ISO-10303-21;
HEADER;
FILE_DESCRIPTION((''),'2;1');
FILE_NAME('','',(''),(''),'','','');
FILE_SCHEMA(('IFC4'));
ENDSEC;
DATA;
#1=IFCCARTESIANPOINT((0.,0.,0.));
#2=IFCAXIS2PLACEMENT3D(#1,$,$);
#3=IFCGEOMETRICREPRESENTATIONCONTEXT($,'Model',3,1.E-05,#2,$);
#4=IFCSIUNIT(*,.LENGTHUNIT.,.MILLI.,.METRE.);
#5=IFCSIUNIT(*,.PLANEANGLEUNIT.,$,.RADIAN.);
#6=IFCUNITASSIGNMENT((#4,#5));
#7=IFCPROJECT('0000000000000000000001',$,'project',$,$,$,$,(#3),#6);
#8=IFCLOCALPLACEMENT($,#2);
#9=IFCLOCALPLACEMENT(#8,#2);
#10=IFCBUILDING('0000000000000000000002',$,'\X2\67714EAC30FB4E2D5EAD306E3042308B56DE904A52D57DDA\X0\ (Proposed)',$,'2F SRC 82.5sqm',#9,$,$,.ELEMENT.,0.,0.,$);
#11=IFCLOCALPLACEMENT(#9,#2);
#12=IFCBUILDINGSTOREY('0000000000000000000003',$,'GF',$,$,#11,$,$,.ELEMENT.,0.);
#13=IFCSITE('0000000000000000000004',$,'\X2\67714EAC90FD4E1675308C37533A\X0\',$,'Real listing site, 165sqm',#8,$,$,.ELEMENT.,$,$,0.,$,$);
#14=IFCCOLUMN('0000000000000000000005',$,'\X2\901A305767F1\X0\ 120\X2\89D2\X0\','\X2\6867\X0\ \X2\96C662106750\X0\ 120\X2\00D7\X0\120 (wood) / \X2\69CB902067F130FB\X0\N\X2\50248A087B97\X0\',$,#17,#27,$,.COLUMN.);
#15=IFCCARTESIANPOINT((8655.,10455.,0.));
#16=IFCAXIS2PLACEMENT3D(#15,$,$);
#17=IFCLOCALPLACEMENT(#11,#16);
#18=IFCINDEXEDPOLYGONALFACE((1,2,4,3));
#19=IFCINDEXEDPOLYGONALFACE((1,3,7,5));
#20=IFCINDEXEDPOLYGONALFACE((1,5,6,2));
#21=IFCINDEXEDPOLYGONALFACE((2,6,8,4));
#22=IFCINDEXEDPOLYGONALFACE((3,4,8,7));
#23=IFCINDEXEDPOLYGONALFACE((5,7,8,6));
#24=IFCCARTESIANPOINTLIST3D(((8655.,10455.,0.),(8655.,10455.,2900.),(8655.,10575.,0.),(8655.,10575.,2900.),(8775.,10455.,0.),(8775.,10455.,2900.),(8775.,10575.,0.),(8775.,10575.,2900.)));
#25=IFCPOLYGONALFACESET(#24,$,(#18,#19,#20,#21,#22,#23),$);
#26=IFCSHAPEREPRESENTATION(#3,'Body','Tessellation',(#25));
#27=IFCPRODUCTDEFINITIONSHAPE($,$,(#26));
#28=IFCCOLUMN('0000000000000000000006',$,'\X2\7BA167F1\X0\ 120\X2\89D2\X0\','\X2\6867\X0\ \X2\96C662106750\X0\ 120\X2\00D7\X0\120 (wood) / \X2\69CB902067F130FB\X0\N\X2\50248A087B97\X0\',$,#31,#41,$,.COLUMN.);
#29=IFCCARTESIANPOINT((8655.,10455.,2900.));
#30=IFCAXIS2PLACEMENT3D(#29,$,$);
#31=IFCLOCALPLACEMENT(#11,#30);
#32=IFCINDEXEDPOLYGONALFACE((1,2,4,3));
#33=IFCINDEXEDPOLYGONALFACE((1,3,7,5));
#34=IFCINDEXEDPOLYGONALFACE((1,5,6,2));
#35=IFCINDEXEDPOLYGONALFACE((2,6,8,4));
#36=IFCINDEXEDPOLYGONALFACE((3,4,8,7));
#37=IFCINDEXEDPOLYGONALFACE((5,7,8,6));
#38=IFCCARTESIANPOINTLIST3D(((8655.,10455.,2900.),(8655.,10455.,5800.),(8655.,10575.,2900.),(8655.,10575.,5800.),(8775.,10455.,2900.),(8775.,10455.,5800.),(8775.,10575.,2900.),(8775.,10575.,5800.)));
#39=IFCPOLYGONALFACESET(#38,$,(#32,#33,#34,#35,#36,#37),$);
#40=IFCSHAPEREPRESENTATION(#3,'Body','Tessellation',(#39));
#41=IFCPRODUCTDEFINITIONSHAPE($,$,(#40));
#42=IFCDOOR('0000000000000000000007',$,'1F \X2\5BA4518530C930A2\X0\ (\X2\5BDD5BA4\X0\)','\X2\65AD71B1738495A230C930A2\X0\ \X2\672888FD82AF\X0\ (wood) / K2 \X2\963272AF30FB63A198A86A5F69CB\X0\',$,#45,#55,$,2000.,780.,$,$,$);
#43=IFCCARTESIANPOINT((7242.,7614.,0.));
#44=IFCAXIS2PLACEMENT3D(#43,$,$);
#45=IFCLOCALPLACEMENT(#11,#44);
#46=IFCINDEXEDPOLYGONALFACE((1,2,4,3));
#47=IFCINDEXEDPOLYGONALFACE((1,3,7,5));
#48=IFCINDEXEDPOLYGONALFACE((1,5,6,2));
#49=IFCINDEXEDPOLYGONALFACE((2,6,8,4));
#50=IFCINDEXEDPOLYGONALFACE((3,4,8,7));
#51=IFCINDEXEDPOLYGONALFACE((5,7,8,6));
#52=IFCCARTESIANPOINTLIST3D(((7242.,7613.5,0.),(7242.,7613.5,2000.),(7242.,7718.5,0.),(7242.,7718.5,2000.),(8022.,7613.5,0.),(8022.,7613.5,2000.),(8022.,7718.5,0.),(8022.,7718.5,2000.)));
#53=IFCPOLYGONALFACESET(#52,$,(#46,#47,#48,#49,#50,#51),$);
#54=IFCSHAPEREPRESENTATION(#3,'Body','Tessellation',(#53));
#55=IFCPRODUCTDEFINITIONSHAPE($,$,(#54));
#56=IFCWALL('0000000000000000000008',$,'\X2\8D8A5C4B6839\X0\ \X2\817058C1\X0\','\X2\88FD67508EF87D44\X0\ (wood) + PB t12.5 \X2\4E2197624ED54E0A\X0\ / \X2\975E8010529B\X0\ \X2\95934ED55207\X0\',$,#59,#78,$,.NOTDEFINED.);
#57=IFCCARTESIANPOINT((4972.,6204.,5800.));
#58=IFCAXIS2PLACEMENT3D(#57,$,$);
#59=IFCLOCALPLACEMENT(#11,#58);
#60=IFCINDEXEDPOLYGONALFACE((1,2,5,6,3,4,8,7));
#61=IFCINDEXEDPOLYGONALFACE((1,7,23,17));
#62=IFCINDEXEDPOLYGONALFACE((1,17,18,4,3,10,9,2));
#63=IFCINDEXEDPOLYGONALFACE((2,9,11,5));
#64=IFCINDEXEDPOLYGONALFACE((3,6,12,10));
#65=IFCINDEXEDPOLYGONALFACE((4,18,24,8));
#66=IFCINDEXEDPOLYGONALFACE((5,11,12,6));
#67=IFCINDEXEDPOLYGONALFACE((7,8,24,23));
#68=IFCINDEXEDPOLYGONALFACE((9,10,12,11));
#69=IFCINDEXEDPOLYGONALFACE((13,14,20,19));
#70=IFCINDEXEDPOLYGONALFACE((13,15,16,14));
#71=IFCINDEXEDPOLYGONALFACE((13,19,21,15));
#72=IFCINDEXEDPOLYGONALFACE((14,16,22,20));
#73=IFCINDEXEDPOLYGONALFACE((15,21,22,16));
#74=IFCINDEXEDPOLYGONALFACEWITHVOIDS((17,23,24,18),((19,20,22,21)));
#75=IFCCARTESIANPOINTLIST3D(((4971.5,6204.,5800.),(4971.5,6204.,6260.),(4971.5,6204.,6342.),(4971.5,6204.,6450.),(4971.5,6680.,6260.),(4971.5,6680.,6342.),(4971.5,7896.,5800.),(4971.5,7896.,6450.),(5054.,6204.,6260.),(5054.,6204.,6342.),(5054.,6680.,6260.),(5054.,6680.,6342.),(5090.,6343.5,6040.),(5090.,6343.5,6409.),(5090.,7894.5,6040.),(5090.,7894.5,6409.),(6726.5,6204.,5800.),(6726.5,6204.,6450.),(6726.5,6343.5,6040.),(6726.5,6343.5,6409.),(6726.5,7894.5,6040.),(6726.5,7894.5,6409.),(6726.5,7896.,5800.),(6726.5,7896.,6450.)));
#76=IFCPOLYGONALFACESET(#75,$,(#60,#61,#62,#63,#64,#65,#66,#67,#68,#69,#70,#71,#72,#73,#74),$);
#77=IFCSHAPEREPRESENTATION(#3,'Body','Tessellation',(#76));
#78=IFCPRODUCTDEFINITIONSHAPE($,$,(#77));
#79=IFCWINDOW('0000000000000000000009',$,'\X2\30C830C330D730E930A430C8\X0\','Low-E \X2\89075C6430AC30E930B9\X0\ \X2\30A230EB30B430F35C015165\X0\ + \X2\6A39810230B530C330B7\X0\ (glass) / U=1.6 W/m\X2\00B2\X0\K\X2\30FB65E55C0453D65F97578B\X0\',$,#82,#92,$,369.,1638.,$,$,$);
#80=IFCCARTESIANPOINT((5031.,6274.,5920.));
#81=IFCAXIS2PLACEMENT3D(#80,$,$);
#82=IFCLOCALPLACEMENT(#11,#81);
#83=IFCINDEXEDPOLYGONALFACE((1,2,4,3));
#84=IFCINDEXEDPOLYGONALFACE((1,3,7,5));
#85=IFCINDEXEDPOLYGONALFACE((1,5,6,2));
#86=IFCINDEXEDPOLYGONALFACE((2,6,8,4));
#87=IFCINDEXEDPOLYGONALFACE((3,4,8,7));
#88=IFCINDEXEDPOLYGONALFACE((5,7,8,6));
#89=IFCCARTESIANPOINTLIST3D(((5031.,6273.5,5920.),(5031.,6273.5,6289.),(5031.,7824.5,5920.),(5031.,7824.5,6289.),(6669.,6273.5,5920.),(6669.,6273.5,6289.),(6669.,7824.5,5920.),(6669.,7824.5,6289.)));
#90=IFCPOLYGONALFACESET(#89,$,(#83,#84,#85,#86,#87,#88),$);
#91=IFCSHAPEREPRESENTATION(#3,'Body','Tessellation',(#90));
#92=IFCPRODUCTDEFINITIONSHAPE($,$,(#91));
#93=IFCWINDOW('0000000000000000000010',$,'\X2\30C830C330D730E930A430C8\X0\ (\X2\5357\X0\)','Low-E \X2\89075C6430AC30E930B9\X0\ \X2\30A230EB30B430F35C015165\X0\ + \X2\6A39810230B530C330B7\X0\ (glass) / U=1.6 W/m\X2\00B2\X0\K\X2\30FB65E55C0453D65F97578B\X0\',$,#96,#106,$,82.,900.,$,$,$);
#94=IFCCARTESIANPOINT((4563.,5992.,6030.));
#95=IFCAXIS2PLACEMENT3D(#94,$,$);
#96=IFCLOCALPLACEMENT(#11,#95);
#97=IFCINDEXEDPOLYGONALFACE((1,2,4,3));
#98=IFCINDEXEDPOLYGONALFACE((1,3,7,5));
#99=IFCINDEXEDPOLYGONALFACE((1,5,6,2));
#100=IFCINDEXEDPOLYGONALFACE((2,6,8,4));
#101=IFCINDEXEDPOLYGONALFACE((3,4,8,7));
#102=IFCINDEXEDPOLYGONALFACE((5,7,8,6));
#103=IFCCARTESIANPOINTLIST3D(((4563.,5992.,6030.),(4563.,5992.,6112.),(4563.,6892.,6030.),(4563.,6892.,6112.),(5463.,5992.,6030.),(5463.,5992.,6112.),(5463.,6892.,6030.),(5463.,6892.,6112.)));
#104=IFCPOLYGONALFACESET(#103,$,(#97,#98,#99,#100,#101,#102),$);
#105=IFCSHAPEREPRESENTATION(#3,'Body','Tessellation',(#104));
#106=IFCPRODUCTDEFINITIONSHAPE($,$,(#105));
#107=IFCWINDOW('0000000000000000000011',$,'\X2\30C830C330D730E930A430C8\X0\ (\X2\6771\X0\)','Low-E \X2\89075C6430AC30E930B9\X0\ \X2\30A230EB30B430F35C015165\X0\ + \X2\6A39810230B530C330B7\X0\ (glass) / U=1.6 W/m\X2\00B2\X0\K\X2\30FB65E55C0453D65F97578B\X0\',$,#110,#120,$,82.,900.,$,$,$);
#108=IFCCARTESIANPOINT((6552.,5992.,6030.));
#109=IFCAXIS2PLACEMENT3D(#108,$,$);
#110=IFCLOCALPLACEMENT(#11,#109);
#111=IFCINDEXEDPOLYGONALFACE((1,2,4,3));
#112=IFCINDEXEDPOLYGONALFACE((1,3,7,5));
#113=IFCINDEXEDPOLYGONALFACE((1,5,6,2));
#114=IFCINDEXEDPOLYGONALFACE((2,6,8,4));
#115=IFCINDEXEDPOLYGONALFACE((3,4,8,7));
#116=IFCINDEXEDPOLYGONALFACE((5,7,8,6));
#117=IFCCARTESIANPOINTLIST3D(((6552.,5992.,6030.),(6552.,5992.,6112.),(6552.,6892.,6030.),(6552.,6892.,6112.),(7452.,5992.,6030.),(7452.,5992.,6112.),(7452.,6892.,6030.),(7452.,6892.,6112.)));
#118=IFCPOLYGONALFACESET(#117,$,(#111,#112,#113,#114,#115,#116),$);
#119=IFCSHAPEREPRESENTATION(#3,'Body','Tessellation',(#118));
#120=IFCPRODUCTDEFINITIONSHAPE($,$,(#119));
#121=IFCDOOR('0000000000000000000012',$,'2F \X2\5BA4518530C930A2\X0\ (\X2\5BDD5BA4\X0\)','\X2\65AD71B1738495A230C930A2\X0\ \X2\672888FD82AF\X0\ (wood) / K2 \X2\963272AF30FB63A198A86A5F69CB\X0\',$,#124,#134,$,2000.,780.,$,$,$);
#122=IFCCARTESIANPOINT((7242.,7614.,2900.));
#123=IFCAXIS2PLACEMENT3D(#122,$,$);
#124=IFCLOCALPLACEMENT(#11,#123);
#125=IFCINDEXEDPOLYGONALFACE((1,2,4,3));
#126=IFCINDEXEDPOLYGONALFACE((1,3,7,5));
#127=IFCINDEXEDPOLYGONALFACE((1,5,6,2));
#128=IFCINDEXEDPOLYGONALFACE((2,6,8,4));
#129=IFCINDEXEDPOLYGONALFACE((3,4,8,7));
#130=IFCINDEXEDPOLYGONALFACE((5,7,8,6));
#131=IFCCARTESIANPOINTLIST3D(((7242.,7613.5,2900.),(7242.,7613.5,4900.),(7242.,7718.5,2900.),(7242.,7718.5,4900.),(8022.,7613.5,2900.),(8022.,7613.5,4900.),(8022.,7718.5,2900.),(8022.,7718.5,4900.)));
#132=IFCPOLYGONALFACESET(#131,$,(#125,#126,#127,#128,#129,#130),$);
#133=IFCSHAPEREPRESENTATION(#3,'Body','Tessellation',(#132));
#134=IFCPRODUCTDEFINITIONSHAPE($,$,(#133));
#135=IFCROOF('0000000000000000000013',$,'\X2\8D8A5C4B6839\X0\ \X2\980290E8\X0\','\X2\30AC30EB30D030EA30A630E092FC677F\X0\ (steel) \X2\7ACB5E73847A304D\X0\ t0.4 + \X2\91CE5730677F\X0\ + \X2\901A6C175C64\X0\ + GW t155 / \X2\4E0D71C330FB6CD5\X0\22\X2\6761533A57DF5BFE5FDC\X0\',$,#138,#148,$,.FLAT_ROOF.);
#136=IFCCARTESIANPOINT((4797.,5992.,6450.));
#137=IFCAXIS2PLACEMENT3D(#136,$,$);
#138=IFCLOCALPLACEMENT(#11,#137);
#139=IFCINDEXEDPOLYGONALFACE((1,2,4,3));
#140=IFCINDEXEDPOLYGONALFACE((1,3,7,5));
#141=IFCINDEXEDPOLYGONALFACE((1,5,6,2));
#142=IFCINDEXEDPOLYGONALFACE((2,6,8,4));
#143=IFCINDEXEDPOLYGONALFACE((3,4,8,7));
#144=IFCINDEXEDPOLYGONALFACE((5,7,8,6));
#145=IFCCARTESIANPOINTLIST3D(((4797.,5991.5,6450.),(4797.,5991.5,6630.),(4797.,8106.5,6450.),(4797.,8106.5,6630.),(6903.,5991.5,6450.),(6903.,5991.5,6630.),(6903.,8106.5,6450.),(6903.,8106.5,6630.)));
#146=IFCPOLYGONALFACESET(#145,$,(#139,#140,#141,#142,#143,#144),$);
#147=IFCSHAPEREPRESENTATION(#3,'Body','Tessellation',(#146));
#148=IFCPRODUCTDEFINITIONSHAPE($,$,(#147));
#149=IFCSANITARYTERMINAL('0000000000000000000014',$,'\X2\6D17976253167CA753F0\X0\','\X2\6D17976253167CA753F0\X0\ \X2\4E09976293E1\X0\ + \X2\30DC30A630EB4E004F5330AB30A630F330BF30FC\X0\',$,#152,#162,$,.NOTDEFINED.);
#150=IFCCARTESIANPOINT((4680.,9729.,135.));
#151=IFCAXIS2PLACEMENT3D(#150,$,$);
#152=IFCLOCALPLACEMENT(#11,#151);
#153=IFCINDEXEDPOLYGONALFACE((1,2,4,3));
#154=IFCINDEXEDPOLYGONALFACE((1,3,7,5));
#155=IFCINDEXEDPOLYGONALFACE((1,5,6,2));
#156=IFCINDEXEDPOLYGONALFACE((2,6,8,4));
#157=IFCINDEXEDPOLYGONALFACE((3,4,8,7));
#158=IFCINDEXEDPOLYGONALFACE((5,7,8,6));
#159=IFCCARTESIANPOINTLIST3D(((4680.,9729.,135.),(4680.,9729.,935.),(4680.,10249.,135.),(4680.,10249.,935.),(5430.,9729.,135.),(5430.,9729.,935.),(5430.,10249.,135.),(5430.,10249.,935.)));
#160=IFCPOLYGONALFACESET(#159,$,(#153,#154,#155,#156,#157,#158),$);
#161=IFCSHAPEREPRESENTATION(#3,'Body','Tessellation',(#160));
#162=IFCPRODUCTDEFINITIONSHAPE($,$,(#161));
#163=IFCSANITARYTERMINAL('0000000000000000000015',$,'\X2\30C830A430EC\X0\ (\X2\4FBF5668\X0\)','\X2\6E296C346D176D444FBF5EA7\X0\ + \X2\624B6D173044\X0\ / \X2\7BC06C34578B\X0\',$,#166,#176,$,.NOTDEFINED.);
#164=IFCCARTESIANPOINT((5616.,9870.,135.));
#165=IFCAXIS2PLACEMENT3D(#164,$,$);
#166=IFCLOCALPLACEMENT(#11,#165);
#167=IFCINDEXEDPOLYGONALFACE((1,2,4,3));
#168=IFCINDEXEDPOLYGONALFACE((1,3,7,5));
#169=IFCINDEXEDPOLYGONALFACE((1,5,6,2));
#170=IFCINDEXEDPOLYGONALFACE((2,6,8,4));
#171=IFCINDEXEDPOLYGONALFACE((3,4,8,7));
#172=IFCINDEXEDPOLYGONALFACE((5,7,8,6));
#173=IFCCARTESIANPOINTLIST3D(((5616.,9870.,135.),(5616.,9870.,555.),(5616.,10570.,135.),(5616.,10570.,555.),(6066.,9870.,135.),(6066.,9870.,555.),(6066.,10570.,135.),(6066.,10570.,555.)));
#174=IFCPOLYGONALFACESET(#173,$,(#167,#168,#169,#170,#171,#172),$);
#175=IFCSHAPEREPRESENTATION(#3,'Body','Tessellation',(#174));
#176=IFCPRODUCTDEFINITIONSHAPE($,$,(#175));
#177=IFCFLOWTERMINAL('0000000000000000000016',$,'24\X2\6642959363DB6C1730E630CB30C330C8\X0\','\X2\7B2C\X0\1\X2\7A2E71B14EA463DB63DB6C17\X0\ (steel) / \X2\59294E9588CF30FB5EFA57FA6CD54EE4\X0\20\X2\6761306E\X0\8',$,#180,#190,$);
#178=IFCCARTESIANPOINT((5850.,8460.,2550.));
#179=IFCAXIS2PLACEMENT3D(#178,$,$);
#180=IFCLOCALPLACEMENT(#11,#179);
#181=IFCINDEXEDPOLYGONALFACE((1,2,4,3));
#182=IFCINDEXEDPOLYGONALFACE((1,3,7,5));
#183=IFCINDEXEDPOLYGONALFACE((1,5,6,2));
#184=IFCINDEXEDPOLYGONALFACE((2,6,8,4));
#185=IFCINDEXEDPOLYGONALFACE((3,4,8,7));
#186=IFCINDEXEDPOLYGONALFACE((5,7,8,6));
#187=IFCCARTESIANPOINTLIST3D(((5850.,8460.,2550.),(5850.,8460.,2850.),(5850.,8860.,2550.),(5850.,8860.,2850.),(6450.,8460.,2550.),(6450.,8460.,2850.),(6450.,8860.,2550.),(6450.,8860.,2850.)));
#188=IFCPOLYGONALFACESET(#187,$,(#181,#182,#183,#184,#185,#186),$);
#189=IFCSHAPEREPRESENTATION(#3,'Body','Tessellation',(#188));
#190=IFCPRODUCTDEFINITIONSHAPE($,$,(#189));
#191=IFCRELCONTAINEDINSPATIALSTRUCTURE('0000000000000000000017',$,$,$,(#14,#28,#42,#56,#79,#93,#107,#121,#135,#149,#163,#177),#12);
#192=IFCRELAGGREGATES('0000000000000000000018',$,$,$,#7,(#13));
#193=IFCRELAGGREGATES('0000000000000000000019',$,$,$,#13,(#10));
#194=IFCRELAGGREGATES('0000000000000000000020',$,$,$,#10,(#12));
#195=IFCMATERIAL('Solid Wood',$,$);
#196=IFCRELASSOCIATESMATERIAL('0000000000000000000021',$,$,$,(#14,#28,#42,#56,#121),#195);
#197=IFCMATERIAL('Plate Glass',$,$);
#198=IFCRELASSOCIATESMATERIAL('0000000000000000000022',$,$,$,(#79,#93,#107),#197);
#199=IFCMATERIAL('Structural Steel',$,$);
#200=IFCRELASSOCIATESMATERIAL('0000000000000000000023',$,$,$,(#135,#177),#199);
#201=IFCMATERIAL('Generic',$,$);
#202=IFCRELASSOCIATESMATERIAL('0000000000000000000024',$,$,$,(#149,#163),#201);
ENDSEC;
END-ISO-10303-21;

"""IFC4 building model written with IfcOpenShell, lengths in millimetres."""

from ifc_helpers import new_model, si_unit, frame, frame_2d, origin, place, context, project, spatial, rectangle, extrude, material, element, fill, save


model = new_model("IFC4")

# Units and contexts
model_context = context("Model", 3, precision=1e-05, world=origin())
ifc_project = project(units=[si_unit("LENGTHUNIT", "METRE", prefix="MILLI"), si_unit("PLANEANGLEUNIT", "RADIAN")], contexts=[model_context])

# Site, building, storey
site_placement = place(None, origin())
site = spatial("IfcSite", under=ifc_project, at=site_placement, Name="東京都世田谷区", ObjectType="Real listing site, 165sqm", CompositionType="ELEMENT", RefElevation=0.0)
building_placement = place(site_placement, origin())
building = spatial("IfcBuilding", under=site, at=building_placement, Name="東京・中庭のある回遊動線 (Proposed)", ObjectType="2F SRC 82.5sqm", CompositionType="ELEMENT", ElevationOfRefHeight=0.0, ElevationOfTerrain=0.0)
storey_placement = place(building_placement, origin())
storey = spatial("IfcBuildingStorey", under=building, at=storey_placement, Name="GF", CompositionType="ELEMENT", Elevation=0.0)

# Columns
ifc_material_1 = material(Name="Solid Wood")
column_1_placement = place(storey_placement, frame((8655.0, 10455.0, 0.0)))
element("IfcColumn", 1, at=column_1_placement, inside=storey, material=ifc_material_1, Name="通し柱 120角", Description="桧 集成材 120×120 (wood) / 構造柱・N値計算", PredefinedType="COLUMN", context=model_context, shape_type="SweptSolid", body=[
    extrude(rectangle(XDim=120.0, YDim=120.0, at=frame_2d((60.0, 60.0))), frame((8655.0, 10455.0, 0.0)), (0.0, 0.0, 1.0), 2900.0),
])
column_2_placement = place(storey_placement, frame((8655.0, 10455.0, 2900.0)))
element("IfcColumn", 2, at=column_2_placement, inside=storey, material=ifc_material_1, Name="管柱 120角", Description="桧 集成材 120×120 (wood) / 構造柱・N値計算", PredefinedType="COLUMN", context=model_context, shape_type="SweptSolid", body=[
    extrude(rectangle(XDim=120.0, YDim=120.0, at=frame_2d((60.0, 60.0))), frame((8655.0, 10455.0, 2900.0)), (0.0, 0.0, 1.0), 2900.0),
])

# Door
door_1_placement = place(storey_placement, frame((7242.0, 7614.0, 0.0)))
element("IfcDoor", 3, at=door_1_placement, inside=storey, material=ifc_material_1, Name="1F 室内ドア (寝室)", Description="断熱玄関ドア 木製芯 (wood) / K2 防犯・採風機構", OverallHeight=2000.0, OverallWidth=780.0, context=model_context, shape_type="SweptSolid", body=[
    extrude(rectangle(XDim=780.0, YDim=105.0, at=frame_2d((390.0, 52.0))), frame((7242.0, 7614.0, 0.0)), (0.0, 0.0, 1.0), 2000.0),
])

# Wall, openings, windows
wall_1_placement = place(storey_placement, frame((4972.0, 6204.0, 5800.0)))
wall_1 = element("IfcWall", 4, at=wall_1_placement, inside=storey, material=ifc_material_1, Name="越屋根 腰壁", Description="製材軸組 (wood) + PB t12.5 両面仕上 / 非耐力 間仕切", PredefinedType="NOTDEFINED", context=model_context, shape_type="SweptSolid", body=[
    extrude(rectangle(XDim=1755.0, YDim=1692.0, at=frame_2d((877.0, 846.0))), frame((4972.0, 6204.0, 5800.0)), (0.0, 0.0, 1.0), 650.0),
])
opening_1_placement = place(storey_placement, frame((5031.0, 6274.0, 5920.0)))
opening_1 = element("IfcOpeningElement", 5, at=opening_1_placement, cuts=wall_1, PredefinedType="NOTDEFINED", context=model_context, shape_type="SweptSolid", body=[
    extrude(rectangle(XDim=1638.0, YDim=1551.0, at=frame_2d((819.0, 775.0))), frame((5031.0, 6274.0, 5920.0)), (0.0, 0.0, 1.0), 369.0),
])
opening_2_placement = place(storey_placement, frame((4563.0, 5992.0, 6030.0)))
opening_2 = element("IfcOpeningElement", 6, at=opening_2_placement, cuts=wall_1, PredefinedType="NOTDEFINED", context=model_context, shape_type="SweptSolid", body=[
    extrude(rectangle(XDim=900.0, YDim=900.0, at=frame_2d((450.0, 450.0))), frame((4563.0, 5992.0, 6030.0)), (0.0, 0.0, 1.0), 82.0),
])
opening_3_placement = place(storey_placement, frame((6552.0, 5992.0, 6030.0)))
opening_3 = element("IfcOpeningElement", 7, at=opening_3_placement, cuts=wall_1, PredefinedType="NOTDEFINED", context=model_context, shape_type="SweptSolid", body=[
    extrude(rectangle(XDim=900.0, YDim=900.0, at=frame_2d((450.0, 450.0))), frame((6552.0, 5992.0, 6030.0)), (0.0, 0.0, 1.0), 82.0),
])
ifc_material_2 = material(Name="Plate Glass")
window_1_placement = place(storey_placement, frame((5031.0, 6274.0, 5920.0)))
window_1 = element("IfcWindow", 8, at=window_1_placement, inside=storey, material=ifc_material_2, Name="トップライト", Description="Low-E 複層ガラス アルゴン封入 + 樹脂サッシ (glass) / U=1.6 W/m²K・日射取得型", OverallHeight=369.0, OverallWidth=1638.0, context=model_context, shape_type="SweptSolid", body=[
    extrude(rectangle(XDim=1638.0, YDim=1551.0, at=frame_2d((819.0, 775.0))), frame((5031.0, 6274.0, 5920.0)), (0.0, 0.0, 1.0), 369.0),
])
fill(opening_1, window_1)
window_2_placement = place(storey_placement, frame((4563.0, 5992.0, 6030.0)))
window_2 = element("IfcWindow", 9, at=window_2_placement, inside=storey, material=ifc_material_2, Name="トップライト (南)", Description="Low-E 複層ガラス アルゴン封入 + 樹脂サッシ (glass) / U=1.6 W/m²K・日射取得型", OverallHeight=82.0, OverallWidth=900.0, context=model_context, shape_type="SweptSolid", body=[
    extrude(rectangle(XDim=900.0, YDim=900.0, at=frame_2d((450.0, 450.0))), frame((4563.0, 5992.0, 6030.0)), (0.0, 0.0, 1.0), 82.0),
])
fill(opening_2, window_2)
window_3_placement = place(storey_placement, frame((6552.0, 5992.0, 6030.0)))
window_3 = element("IfcWindow", 10, at=window_3_placement, inside=storey, material=ifc_material_2, Name="トップライト (東)", Description="Low-E 複層ガラス アルゴン封入 + 樹脂サッシ (glass) / U=1.6 W/m²K・日射取得型", OverallHeight=82.0, OverallWidth=900.0, context=model_context, shape_type="SweptSolid", body=[
    extrude(rectangle(XDim=900.0, YDim=900.0, at=frame_2d((450.0, 450.0))), frame((6552.0, 5992.0, 6030.0)), (0.0, 0.0, 1.0), 82.0),
])
fill(opening_3, window_3)

# Door
door_2_placement = place(storey_placement, frame((7242.0, 7614.0, 2900.0)))
element("IfcDoor", 11, at=door_2_placement, inside=storey, material=ifc_material_1, Name="2F 室内ドア (寝室)", Description="断熱玄関ドア 木製芯 (wood) / K2 防犯・採風機構", OverallHeight=2000.0, OverallWidth=780.0, context=model_context, shape_type="SweptSolid", body=[
    extrude(rectangle(XDim=780.0, YDim=105.0, at=frame_2d((390.0, 52.0))), frame((7242.0, 7614.0, 2900.0)), (0.0, 0.0, 1.0), 2000.0),
])

# Roof
ifc_material_3 = material(Name="Structural Steel")
roof_placement = place(storey_placement, frame((4797.0, 5992.0, 6450.0)))
element("IfcRoof", 12, at=roof_placement, inside=storey, material=ifc_material_3, Name="越屋根 頂部", Description="ガルバリウム鋼板 (steel) 立平葺き t0.4 + 野地板 + 通気層 + GW t155 / 不燃・法22条区域対応", PredefinedType="FLAT_ROOF", context=model_context, shape_type="SweptSolid", body=[
    extrude(rectangle(XDim=2106.0, YDim=2115.0, at=frame_2d((1053.0, 1057.0))), frame((4797.0, 5992.0, 6450.0)), (0.0, 0.0, 1.0), 180.0),
])

# Sanitary terminals
ifc_material_4 = material(Name="Generic")
sanitary_terminal_1_placement = place(storey_placement, frame((4680.0, 9729.0, 135.0)))
element("IfcSanitaryTerminal", 13, at=sanitary_terminal_1_placement, inside=storey, material=ifc_material_4, Name="洗面化粧台", Description="洗面化粧台 三面鏡 + ボウル一体カウンター", PredefinedType="NOTDEFINED", context=model_context, shape_type="SweptSolid", body=[
    extrude(rectangle(XDim=750.0, YDim=520.0, at=frame_2d((375.0, 260.0))), frame((4680.0, 9729.0, 135.0)), (0.0, 0.0, 1.0), 800.0),
])
sanitary_terminal_2_placement = place(storey_placement, frame((5616.0, 9870.0, 135.0)))
element("IfcSanitaryTerminal", 14, at=sanitary_terminal_2_placement, inside=storey, material=ifc_material_4, Name="トイレ (便器)", Description="温水洗浄便座 + 手洗い / 節水型", PredefinedType="NOTDEFINED", context=model_context, shape_type="SweptSolid", body=[
    extrude(rectangle(XDim=450.0, YDim=700.0, at=frame_2d((225.0, 350.0))), frame((5616.0, 9870.0, 135.0)), (0.0, 0.0, 1.0), 420.0),
])

# Flow terminal
flow_terminal_placement = place(storey_placement, frame((5850.0, 8460.0, 2550.0)))
element("IfcFlowTerminal", 15, at=flow_terminal_placement, inside=storey, material=ifc_material_3, Name="24時間換気ユニット", Description="第1種熱交換換気 (steel) / 天井裏・建基法令20条の8", context=model_context, shape_type="SweptSolid", body=[
    extrude(rectangle(XDim=600.0, YDim=400.0, at=frame_2d((300.0, 200.0))), frame((5850.0, 8460.0, 2550.0)), (0.0, 0.0, 1.0), 300.0),
])

save(model, "model.ifc")
